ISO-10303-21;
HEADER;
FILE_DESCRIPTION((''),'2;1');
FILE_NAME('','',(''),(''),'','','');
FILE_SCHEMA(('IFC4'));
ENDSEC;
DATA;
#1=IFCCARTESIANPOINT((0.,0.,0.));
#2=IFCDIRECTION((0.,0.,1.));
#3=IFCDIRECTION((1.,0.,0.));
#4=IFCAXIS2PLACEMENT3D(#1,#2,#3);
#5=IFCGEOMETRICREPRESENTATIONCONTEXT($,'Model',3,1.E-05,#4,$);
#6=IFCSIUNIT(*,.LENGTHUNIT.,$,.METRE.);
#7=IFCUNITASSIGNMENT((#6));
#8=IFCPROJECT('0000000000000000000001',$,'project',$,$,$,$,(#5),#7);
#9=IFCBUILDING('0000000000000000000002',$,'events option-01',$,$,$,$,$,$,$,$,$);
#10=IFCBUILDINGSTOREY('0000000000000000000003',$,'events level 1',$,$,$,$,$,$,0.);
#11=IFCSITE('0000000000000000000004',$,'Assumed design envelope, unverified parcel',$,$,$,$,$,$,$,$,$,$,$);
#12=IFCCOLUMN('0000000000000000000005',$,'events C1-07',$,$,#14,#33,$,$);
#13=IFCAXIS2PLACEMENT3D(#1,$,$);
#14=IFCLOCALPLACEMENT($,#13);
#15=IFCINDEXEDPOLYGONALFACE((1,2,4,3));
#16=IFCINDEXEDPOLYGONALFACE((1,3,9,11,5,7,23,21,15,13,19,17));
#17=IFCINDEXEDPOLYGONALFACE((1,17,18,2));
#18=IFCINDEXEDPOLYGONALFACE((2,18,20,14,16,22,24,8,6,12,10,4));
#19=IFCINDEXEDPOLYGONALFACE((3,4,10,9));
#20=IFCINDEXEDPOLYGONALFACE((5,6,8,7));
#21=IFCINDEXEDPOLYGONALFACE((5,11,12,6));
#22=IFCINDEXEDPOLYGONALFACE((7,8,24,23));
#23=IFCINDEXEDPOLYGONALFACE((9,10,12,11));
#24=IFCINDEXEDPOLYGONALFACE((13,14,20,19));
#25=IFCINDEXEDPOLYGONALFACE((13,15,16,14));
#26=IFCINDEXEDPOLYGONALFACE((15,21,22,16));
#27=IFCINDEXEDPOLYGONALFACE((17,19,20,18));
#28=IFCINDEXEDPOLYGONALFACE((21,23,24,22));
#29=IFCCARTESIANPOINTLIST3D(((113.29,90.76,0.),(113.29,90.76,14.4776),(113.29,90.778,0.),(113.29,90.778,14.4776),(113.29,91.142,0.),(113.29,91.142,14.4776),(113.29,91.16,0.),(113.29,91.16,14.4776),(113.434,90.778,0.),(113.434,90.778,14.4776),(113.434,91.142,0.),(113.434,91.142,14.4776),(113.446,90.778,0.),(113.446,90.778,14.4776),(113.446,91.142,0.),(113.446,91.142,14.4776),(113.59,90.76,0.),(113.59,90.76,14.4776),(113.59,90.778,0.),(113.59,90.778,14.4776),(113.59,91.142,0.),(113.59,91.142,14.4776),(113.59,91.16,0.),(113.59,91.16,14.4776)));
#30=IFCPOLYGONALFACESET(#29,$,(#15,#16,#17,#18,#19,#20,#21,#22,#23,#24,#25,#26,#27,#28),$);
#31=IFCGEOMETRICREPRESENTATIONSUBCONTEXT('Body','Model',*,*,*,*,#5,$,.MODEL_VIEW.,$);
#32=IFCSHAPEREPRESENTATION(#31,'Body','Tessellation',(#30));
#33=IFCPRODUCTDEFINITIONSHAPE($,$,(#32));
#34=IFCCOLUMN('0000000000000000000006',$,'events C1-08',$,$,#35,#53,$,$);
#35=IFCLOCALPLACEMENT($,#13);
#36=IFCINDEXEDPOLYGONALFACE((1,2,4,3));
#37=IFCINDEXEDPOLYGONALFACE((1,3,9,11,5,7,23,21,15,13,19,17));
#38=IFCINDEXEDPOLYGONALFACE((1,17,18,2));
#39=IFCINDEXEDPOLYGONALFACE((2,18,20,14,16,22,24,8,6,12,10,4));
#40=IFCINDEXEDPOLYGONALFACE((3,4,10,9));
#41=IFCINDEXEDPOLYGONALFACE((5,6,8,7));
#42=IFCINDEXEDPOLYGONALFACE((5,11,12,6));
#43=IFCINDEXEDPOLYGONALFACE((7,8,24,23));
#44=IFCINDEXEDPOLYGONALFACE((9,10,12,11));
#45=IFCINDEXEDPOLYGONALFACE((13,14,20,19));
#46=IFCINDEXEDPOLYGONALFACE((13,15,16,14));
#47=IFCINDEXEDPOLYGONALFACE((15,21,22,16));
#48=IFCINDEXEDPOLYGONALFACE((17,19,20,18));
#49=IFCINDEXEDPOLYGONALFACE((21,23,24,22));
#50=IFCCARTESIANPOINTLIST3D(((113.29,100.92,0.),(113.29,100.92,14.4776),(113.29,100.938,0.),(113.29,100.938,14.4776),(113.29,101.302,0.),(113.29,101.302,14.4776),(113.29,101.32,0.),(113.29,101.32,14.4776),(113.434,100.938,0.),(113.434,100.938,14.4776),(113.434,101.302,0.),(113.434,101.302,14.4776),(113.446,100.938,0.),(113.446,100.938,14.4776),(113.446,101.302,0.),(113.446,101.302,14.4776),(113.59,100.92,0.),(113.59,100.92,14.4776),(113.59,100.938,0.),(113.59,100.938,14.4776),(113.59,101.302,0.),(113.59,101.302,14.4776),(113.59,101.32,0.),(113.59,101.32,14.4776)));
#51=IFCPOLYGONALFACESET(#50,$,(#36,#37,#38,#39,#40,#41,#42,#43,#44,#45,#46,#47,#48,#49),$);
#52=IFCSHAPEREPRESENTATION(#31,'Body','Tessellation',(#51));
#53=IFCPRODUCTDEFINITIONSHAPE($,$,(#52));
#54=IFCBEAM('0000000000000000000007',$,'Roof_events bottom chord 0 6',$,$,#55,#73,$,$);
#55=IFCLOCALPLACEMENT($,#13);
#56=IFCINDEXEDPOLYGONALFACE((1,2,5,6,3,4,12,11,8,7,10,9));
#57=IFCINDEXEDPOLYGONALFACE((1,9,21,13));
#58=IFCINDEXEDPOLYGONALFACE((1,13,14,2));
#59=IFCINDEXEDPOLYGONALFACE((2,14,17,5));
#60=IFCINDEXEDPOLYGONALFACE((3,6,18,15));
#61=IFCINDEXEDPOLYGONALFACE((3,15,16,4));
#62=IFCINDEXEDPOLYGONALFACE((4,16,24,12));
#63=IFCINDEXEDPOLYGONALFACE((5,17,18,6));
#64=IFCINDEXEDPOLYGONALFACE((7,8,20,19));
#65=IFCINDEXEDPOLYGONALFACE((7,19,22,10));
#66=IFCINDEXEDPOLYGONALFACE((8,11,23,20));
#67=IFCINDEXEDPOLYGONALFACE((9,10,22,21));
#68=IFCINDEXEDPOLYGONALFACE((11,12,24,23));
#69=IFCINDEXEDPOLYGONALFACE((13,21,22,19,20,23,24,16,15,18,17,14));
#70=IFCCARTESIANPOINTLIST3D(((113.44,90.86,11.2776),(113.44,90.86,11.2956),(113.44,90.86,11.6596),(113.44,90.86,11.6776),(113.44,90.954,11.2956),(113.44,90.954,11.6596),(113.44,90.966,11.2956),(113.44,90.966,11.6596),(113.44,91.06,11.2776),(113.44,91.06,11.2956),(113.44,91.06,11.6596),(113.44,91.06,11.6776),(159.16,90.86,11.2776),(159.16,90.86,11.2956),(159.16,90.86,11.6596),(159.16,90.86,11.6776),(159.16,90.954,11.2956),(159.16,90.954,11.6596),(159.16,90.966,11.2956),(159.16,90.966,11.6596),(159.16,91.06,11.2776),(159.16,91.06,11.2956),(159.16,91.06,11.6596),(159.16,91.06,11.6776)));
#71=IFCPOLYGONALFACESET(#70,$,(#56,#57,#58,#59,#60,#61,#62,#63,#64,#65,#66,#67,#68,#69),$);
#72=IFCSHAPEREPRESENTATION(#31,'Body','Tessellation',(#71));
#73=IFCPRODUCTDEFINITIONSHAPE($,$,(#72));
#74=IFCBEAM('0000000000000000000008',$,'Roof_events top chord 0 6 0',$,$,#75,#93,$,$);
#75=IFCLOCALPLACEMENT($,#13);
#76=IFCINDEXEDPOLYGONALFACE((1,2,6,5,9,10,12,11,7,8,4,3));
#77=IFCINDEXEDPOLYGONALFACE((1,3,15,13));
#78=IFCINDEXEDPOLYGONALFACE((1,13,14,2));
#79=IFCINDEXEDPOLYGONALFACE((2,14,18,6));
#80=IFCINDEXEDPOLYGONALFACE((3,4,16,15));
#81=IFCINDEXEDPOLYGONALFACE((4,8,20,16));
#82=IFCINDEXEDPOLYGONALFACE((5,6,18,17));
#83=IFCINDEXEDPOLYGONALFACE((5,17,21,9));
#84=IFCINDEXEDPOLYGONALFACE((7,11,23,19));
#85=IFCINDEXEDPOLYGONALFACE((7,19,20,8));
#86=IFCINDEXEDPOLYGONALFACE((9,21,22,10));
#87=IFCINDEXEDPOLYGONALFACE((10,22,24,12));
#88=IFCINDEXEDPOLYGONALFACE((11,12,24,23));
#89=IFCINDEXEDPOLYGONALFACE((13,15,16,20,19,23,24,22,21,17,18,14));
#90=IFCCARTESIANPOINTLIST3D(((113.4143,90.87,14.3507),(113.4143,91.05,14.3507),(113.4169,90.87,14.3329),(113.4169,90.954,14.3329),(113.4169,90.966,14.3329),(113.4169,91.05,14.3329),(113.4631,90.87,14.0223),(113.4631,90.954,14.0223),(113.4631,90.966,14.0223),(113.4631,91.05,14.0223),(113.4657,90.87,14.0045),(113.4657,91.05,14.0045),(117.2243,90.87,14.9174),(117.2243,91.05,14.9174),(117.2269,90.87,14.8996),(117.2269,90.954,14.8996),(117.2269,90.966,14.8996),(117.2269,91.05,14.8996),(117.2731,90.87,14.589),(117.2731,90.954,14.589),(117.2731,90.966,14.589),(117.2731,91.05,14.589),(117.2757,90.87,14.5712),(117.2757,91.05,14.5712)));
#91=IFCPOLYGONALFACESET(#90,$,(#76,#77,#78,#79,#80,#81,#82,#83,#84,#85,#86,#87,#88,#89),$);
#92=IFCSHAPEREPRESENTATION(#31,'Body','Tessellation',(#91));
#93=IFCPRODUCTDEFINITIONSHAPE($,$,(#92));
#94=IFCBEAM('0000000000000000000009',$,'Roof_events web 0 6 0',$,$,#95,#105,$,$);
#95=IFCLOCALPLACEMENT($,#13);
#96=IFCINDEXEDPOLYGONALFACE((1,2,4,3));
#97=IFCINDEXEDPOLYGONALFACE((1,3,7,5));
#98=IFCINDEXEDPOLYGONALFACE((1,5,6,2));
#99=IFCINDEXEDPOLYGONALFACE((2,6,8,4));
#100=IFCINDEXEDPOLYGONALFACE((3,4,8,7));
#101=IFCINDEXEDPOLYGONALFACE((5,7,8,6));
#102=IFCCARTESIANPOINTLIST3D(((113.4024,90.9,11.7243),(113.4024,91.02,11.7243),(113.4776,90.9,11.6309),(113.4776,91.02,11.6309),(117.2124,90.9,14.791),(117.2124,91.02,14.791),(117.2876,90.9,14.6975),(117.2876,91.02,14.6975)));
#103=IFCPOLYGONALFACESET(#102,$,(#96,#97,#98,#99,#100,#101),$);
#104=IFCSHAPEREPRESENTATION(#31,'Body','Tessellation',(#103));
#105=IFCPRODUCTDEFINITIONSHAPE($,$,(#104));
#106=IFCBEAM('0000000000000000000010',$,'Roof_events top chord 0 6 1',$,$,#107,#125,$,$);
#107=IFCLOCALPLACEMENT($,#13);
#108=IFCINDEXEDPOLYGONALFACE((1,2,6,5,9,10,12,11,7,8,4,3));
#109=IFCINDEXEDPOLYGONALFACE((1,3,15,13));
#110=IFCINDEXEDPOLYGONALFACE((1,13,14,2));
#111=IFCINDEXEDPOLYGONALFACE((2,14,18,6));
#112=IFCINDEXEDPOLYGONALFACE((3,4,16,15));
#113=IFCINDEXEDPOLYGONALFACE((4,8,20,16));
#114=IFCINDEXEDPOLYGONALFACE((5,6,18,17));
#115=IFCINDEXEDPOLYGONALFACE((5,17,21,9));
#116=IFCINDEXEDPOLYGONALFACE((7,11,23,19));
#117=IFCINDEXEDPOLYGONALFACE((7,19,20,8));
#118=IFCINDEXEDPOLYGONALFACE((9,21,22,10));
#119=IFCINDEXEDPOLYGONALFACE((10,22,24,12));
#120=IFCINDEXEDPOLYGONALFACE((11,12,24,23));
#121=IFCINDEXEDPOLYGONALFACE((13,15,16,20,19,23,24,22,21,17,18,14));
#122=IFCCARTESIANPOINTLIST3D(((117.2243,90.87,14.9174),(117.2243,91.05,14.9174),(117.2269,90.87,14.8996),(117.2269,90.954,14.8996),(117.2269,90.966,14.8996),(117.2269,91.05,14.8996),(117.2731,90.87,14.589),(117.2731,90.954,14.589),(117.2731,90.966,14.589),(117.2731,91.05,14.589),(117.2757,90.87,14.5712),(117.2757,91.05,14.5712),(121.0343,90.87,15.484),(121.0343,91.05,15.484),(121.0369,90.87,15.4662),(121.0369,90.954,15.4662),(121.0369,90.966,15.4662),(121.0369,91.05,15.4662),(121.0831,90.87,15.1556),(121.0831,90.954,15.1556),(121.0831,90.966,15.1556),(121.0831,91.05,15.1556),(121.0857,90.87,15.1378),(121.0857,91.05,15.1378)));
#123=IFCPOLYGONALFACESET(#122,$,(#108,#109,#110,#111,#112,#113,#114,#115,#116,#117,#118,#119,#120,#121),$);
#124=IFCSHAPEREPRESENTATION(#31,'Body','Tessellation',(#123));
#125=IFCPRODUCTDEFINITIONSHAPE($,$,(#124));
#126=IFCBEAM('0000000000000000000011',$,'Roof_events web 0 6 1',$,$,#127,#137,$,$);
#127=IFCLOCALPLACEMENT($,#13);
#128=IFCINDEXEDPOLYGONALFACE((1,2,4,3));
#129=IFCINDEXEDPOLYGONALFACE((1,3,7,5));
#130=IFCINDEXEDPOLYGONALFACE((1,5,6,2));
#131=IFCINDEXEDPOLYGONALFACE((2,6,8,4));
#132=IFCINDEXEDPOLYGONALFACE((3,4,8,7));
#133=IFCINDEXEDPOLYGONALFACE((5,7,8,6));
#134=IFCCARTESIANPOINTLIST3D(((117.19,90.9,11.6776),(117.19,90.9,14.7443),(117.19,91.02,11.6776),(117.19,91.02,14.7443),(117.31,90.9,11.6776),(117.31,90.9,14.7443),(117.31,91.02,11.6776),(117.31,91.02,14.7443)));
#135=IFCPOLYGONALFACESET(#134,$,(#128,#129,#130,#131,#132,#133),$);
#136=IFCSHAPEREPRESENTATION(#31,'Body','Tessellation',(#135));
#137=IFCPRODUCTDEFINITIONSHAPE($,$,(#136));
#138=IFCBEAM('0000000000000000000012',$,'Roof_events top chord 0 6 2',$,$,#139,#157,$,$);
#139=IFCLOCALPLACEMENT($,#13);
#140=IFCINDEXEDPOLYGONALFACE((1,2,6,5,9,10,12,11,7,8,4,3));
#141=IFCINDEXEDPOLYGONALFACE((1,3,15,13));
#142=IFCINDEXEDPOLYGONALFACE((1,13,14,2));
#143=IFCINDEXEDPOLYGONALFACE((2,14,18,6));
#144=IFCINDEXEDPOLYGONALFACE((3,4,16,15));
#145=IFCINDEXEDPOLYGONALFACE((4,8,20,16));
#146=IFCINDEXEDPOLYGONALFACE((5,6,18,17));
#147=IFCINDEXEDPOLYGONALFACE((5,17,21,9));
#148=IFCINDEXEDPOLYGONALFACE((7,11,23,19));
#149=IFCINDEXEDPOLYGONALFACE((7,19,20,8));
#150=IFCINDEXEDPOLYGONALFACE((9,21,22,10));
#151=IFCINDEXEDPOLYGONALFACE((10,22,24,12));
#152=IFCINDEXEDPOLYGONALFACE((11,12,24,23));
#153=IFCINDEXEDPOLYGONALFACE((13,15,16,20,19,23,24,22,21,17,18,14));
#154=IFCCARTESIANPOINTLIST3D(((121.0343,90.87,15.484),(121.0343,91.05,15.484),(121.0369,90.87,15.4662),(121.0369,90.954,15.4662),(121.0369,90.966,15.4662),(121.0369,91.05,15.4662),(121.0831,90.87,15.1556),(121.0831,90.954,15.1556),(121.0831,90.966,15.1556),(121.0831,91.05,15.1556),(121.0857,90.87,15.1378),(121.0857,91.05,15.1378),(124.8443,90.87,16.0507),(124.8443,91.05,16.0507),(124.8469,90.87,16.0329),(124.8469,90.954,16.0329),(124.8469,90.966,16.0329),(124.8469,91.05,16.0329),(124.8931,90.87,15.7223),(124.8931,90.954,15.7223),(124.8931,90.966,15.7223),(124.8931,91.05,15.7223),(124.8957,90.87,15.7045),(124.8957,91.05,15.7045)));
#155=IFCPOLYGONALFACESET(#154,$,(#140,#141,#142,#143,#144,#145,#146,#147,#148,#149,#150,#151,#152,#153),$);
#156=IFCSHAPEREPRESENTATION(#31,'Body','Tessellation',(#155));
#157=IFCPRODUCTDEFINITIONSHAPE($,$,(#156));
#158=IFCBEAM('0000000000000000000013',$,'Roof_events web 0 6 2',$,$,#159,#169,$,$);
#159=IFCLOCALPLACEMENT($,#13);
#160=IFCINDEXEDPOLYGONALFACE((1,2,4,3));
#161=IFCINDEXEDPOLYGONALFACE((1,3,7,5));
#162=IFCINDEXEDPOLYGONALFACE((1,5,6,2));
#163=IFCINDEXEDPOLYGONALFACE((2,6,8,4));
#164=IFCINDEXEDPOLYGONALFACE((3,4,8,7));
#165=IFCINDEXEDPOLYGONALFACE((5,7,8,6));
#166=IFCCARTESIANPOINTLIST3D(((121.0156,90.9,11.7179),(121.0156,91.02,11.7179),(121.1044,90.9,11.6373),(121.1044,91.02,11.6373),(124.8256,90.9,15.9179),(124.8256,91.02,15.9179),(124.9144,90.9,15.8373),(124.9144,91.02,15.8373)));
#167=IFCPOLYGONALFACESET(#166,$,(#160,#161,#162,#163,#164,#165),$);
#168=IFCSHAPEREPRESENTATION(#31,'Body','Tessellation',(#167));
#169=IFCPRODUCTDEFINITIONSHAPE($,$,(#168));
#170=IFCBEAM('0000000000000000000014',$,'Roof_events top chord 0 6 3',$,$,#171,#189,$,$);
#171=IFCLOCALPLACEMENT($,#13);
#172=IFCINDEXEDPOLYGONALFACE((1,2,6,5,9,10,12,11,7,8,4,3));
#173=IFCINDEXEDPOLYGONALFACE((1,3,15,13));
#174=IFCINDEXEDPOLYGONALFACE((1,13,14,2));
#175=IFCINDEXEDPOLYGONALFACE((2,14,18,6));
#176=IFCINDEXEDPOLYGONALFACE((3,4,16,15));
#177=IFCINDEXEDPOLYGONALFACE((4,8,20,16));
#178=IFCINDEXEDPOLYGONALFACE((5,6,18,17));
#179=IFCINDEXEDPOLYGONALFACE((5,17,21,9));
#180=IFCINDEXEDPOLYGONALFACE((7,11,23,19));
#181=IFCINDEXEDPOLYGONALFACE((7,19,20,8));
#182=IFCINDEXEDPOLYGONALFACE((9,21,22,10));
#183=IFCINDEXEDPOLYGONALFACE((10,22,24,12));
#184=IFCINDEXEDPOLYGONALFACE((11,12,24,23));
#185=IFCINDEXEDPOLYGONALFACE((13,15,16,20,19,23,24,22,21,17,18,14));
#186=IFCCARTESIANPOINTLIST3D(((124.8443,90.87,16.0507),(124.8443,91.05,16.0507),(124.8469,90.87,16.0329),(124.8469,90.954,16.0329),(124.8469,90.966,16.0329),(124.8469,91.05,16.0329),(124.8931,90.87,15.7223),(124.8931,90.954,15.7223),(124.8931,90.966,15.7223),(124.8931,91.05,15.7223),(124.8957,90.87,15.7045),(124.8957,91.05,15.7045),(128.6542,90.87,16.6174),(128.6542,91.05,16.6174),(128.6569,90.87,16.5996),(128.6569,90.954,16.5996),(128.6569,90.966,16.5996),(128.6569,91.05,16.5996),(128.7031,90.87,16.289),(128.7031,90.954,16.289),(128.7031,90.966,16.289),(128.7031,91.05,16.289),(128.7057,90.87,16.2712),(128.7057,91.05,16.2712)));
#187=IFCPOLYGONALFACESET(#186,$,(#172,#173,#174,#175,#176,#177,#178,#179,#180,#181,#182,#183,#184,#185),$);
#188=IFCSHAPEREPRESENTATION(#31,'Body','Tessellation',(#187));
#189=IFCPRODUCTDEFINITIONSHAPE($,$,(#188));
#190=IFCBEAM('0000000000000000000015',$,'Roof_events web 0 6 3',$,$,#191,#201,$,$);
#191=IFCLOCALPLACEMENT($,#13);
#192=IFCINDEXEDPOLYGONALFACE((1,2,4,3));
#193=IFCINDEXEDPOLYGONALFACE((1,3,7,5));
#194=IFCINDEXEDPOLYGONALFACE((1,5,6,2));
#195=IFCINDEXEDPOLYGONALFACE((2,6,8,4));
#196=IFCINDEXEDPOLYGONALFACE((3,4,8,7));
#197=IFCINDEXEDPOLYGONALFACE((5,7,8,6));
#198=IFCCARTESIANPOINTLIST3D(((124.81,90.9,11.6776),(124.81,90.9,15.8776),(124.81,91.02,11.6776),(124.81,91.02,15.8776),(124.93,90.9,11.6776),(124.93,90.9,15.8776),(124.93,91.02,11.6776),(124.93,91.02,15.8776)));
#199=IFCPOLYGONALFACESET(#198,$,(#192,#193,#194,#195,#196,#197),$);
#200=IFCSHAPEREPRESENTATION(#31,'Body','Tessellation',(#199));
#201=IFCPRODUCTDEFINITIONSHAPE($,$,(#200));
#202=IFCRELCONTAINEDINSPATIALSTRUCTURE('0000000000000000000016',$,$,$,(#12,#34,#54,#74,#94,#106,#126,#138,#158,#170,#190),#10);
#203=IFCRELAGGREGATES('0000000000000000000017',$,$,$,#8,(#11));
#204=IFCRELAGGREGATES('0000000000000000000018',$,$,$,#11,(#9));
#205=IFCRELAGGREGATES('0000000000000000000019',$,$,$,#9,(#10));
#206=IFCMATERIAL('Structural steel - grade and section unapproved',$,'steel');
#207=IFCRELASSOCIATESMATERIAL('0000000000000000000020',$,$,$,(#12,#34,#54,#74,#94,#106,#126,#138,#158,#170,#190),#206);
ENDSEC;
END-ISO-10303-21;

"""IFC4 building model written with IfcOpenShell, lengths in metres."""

from ifc_helpers import new_model, si_unit, frame, origin_with_axes, place, context, subcontext, project, spatial, rectangle, i_section, extrude, material, element, save


model = new_model("IFC4")

# Units and contexts
model_context = context("Model", 3, precision=1e-05, world=origin_with_axes())
body_context = subcontext(model_context, "Body", "Model", "MODEL_VIEW")
ifc_project = project(units=[si_unit("LENGTHUNIT", "METRE")], contexts=[model_context])

# Site, building, storey
site = spatial("IfcSite", under=ifc_project, Name="Assumed design envelope, unverified parcel")
building = spatial("IfcBuilding", under=site, Name="events option-01")
storey = spatial("IfcBuildingStorey", under=building, Name="events level 1", Elevation=0.0)

# Columns
ifc_material_1 = material(Name="Structural steel - grade and section unapproved", Category="steel")
for number, where, z_axis, x_axis, name in (
    (1, (113.44, 90.96, 0.0), (0.0, 0.0, 1.0), (-1.0, 0.0, 0.0), "events C1-07"),
    (2, (113.44, 101.12, 0.0), (0.0, 0.0, 1.0), (-1.0, 0.0, 0.0), "events C1-08"),
):
    element("IfcColumn", number, at=place(None, frame(where, z_axis=z_axis, x_axis=x_axis)), inside=storey, material=ifc_material_1, Name=name, context=body_context, shape_type="SweptSolid", body=[
        extrude(i_section(OverallWidth=0.3, OverallDepth=0.4, WebThickness=0.012, FlangeThickness=0.018, FilletRadius=0.0), origin_with_axes(), (0.0, 0.0, 1.0), 14.4776),
    ])

# Beams
beam_1_placement = place(None, frame((113.44, 90.96, 11.4776), z_axis=(1.0, 0.0, 0.0), x_axis=(0.0, 1.0, 0.0)))
element("IfcBeam", 3, at=beam_1_placement, inside=storey, material=ifc_material_1, Name="Roof_events bottom chord 0 6", context=body_context, shape_type="SweptSolid", body=[
    extrude(i_section(OverallWidth=0.2, OverallDepth=0.4, WebThickness=0.012, FlangeThickness=0.018, FilletRadius=0.0), origin_with_axes(), (0.0, 0.0, 1.0), 45.72),
])
beam_2_placement = place(None, frame((113.44, 90.96, 14.1776), z_axis=(0.98912, 0.0, 0.147113), x_axis=(0.0, 1.0, 0.0)))
element("IfcBeam", 4, at=beam_2_placement, inside=storey, material=ifc_material_1, Name="Roof_events top chord 0 6 0", context=body_context, shape_type="SweptSolid", body=[
    extrude(i_section(OverallWidth=0.18, OverallDepth=0.35, WebThickness=0.012, FlangeThickness=0.018, FilletRadius=0.0), origin_with_axes(), (0.0, 0.0, 1.0), 3.8519),
])
beam_3_placement = place(None, frame((113.44, 90.96, 11.6776), z_axis=(0.779003, 0.0, 0.62702), x_axis=(0.0, 1.0, 0.0)))
element("IfcBeam", 5, at=beam_3_placement, inside=storey, material=ifc_material_1, Name="Roof_events web 0 6 0", context=body_context, shape_type="SweptSolid", body=[
    extrude(rectangle(XDim=0.12, YDim=0.12), origin_with_axes(), (0.0, 0.0, 1.0), 4.8909),
])
beam_4_placement = place(None, frame((117.25, 90.96, 14.7443), z_axis=(0.98912, 0.0, 0.147113), x_axis=(0.0, 1.0, 0.0)))
element("IfcBeam", 6, at=beam_4_placement, inside=storey, material=ifc_material_1, Name="Roof_events top chord 0 6 1", context=body_context, shape_type="SweptSolid", body=[
    extrude(i_section(OverallWidth=0.18, OverallDepth=0.35, WebThickness=0.012, FlangeThickness=0.018, FilletRadius=0.0), origin_with_axes(), (0.0, 0.0, 1.0), 3.8519),
])
beam_5_placement = place(None, frame((117.25, 90.96, 11.6776), z_axis=(0.0, 0.0, 1.0), x_axis=(-1.0, 0.0, 0.0)))
element("IfcBeam", 7, at=beam_5_placement, inside=storey, material=ifc_material_1, Name="Roof_events web 0 6 1", context=body_context, shape_type="SweptSolid", body=[
    extrude(rectangle(XDim=0.12, YDim=0.12), origin_with_axes(), (0.0, 0.0, 1.0), 3.0667),
])
beam_6_placement = place(None, frame((121.06, 90.96, 15.3109), z_axis=(0.98912, 0.0, 0.147113), x_axis=(0.0, 1.0, 0.0)))
element("IfcBeam", 8, at=beam_6_placement, inside=storey, material=ifc_material_1, Name="Roof_events top chord 0 6 2", context=body_context, shape_type="SweptSolid", body=[
    extrude(i_section(OverallWidth=0.18, OverallDepth=0.35, WebThickness=0.012, FlangeThickness=0.018, FilletRadius=0.0), origin_with_axes(), (0.0, 0.0, 1.0), 3.8519),
])
beam_7_placement = place(None, frame((121.06, 90.96, 11.6776), z_axis=(0.671883, 0.0, 0.740657), x_axis=(0.0, 1.0, 0.0)))
element("IfcBeam", 9, at=beam_7_placement, inside=storey, material=ifc_material_1, Name="Roof_events web 0 6 2", context=body_context, shape_type="SweptSolid", body=[
    extrude(rectangle(XDim=0.12, YDim=0.12), origin_with_axes(), (0.0, 0.0, 1.0), 5.6706),
])
beam_8_placement = place(None, frame((124.87, 90.96, 15.8776), z_axis=(0.98912, 0.0, 0.147114), x_axis=(0.0, 1.0, 0.0)))
element("IfcBeam", 10, at=beam_8_placement, inside=storey, material=ifc_material_1, Name="Roof_events top chord 0 6 3", context=body_context, shape_type="SweptSolid", body=[
    extrude(i_section(OverallWidth=0.18, OverallDepth=0.35, WebThickness=0.012, FlangeThickness=0.018, FilletRadius=0.0), origin_with_axes(), (0.0, 0.0, 1.0), 3.8519),
])
beam_9_placement = place(None, frame((124.87, 90.96, 11.6776), z_axis=(0.0, 0.0, 1.0), x_axis=(-1.0, 0.0, 0.0)))
element("IfcBeam", 11, at=beam_9_placement, inside=storey, material=ifc_material_1, Name="Roof_events web 0 6 3", context=body_context, shape_type="SweptSolid", body=[
    extrude(rectangle(XDim=0.12, YDim=0.12), origin_with_axes(), (0.0, 0.0, 1.0), 4.2),
])

save(model, "model.ifc")
